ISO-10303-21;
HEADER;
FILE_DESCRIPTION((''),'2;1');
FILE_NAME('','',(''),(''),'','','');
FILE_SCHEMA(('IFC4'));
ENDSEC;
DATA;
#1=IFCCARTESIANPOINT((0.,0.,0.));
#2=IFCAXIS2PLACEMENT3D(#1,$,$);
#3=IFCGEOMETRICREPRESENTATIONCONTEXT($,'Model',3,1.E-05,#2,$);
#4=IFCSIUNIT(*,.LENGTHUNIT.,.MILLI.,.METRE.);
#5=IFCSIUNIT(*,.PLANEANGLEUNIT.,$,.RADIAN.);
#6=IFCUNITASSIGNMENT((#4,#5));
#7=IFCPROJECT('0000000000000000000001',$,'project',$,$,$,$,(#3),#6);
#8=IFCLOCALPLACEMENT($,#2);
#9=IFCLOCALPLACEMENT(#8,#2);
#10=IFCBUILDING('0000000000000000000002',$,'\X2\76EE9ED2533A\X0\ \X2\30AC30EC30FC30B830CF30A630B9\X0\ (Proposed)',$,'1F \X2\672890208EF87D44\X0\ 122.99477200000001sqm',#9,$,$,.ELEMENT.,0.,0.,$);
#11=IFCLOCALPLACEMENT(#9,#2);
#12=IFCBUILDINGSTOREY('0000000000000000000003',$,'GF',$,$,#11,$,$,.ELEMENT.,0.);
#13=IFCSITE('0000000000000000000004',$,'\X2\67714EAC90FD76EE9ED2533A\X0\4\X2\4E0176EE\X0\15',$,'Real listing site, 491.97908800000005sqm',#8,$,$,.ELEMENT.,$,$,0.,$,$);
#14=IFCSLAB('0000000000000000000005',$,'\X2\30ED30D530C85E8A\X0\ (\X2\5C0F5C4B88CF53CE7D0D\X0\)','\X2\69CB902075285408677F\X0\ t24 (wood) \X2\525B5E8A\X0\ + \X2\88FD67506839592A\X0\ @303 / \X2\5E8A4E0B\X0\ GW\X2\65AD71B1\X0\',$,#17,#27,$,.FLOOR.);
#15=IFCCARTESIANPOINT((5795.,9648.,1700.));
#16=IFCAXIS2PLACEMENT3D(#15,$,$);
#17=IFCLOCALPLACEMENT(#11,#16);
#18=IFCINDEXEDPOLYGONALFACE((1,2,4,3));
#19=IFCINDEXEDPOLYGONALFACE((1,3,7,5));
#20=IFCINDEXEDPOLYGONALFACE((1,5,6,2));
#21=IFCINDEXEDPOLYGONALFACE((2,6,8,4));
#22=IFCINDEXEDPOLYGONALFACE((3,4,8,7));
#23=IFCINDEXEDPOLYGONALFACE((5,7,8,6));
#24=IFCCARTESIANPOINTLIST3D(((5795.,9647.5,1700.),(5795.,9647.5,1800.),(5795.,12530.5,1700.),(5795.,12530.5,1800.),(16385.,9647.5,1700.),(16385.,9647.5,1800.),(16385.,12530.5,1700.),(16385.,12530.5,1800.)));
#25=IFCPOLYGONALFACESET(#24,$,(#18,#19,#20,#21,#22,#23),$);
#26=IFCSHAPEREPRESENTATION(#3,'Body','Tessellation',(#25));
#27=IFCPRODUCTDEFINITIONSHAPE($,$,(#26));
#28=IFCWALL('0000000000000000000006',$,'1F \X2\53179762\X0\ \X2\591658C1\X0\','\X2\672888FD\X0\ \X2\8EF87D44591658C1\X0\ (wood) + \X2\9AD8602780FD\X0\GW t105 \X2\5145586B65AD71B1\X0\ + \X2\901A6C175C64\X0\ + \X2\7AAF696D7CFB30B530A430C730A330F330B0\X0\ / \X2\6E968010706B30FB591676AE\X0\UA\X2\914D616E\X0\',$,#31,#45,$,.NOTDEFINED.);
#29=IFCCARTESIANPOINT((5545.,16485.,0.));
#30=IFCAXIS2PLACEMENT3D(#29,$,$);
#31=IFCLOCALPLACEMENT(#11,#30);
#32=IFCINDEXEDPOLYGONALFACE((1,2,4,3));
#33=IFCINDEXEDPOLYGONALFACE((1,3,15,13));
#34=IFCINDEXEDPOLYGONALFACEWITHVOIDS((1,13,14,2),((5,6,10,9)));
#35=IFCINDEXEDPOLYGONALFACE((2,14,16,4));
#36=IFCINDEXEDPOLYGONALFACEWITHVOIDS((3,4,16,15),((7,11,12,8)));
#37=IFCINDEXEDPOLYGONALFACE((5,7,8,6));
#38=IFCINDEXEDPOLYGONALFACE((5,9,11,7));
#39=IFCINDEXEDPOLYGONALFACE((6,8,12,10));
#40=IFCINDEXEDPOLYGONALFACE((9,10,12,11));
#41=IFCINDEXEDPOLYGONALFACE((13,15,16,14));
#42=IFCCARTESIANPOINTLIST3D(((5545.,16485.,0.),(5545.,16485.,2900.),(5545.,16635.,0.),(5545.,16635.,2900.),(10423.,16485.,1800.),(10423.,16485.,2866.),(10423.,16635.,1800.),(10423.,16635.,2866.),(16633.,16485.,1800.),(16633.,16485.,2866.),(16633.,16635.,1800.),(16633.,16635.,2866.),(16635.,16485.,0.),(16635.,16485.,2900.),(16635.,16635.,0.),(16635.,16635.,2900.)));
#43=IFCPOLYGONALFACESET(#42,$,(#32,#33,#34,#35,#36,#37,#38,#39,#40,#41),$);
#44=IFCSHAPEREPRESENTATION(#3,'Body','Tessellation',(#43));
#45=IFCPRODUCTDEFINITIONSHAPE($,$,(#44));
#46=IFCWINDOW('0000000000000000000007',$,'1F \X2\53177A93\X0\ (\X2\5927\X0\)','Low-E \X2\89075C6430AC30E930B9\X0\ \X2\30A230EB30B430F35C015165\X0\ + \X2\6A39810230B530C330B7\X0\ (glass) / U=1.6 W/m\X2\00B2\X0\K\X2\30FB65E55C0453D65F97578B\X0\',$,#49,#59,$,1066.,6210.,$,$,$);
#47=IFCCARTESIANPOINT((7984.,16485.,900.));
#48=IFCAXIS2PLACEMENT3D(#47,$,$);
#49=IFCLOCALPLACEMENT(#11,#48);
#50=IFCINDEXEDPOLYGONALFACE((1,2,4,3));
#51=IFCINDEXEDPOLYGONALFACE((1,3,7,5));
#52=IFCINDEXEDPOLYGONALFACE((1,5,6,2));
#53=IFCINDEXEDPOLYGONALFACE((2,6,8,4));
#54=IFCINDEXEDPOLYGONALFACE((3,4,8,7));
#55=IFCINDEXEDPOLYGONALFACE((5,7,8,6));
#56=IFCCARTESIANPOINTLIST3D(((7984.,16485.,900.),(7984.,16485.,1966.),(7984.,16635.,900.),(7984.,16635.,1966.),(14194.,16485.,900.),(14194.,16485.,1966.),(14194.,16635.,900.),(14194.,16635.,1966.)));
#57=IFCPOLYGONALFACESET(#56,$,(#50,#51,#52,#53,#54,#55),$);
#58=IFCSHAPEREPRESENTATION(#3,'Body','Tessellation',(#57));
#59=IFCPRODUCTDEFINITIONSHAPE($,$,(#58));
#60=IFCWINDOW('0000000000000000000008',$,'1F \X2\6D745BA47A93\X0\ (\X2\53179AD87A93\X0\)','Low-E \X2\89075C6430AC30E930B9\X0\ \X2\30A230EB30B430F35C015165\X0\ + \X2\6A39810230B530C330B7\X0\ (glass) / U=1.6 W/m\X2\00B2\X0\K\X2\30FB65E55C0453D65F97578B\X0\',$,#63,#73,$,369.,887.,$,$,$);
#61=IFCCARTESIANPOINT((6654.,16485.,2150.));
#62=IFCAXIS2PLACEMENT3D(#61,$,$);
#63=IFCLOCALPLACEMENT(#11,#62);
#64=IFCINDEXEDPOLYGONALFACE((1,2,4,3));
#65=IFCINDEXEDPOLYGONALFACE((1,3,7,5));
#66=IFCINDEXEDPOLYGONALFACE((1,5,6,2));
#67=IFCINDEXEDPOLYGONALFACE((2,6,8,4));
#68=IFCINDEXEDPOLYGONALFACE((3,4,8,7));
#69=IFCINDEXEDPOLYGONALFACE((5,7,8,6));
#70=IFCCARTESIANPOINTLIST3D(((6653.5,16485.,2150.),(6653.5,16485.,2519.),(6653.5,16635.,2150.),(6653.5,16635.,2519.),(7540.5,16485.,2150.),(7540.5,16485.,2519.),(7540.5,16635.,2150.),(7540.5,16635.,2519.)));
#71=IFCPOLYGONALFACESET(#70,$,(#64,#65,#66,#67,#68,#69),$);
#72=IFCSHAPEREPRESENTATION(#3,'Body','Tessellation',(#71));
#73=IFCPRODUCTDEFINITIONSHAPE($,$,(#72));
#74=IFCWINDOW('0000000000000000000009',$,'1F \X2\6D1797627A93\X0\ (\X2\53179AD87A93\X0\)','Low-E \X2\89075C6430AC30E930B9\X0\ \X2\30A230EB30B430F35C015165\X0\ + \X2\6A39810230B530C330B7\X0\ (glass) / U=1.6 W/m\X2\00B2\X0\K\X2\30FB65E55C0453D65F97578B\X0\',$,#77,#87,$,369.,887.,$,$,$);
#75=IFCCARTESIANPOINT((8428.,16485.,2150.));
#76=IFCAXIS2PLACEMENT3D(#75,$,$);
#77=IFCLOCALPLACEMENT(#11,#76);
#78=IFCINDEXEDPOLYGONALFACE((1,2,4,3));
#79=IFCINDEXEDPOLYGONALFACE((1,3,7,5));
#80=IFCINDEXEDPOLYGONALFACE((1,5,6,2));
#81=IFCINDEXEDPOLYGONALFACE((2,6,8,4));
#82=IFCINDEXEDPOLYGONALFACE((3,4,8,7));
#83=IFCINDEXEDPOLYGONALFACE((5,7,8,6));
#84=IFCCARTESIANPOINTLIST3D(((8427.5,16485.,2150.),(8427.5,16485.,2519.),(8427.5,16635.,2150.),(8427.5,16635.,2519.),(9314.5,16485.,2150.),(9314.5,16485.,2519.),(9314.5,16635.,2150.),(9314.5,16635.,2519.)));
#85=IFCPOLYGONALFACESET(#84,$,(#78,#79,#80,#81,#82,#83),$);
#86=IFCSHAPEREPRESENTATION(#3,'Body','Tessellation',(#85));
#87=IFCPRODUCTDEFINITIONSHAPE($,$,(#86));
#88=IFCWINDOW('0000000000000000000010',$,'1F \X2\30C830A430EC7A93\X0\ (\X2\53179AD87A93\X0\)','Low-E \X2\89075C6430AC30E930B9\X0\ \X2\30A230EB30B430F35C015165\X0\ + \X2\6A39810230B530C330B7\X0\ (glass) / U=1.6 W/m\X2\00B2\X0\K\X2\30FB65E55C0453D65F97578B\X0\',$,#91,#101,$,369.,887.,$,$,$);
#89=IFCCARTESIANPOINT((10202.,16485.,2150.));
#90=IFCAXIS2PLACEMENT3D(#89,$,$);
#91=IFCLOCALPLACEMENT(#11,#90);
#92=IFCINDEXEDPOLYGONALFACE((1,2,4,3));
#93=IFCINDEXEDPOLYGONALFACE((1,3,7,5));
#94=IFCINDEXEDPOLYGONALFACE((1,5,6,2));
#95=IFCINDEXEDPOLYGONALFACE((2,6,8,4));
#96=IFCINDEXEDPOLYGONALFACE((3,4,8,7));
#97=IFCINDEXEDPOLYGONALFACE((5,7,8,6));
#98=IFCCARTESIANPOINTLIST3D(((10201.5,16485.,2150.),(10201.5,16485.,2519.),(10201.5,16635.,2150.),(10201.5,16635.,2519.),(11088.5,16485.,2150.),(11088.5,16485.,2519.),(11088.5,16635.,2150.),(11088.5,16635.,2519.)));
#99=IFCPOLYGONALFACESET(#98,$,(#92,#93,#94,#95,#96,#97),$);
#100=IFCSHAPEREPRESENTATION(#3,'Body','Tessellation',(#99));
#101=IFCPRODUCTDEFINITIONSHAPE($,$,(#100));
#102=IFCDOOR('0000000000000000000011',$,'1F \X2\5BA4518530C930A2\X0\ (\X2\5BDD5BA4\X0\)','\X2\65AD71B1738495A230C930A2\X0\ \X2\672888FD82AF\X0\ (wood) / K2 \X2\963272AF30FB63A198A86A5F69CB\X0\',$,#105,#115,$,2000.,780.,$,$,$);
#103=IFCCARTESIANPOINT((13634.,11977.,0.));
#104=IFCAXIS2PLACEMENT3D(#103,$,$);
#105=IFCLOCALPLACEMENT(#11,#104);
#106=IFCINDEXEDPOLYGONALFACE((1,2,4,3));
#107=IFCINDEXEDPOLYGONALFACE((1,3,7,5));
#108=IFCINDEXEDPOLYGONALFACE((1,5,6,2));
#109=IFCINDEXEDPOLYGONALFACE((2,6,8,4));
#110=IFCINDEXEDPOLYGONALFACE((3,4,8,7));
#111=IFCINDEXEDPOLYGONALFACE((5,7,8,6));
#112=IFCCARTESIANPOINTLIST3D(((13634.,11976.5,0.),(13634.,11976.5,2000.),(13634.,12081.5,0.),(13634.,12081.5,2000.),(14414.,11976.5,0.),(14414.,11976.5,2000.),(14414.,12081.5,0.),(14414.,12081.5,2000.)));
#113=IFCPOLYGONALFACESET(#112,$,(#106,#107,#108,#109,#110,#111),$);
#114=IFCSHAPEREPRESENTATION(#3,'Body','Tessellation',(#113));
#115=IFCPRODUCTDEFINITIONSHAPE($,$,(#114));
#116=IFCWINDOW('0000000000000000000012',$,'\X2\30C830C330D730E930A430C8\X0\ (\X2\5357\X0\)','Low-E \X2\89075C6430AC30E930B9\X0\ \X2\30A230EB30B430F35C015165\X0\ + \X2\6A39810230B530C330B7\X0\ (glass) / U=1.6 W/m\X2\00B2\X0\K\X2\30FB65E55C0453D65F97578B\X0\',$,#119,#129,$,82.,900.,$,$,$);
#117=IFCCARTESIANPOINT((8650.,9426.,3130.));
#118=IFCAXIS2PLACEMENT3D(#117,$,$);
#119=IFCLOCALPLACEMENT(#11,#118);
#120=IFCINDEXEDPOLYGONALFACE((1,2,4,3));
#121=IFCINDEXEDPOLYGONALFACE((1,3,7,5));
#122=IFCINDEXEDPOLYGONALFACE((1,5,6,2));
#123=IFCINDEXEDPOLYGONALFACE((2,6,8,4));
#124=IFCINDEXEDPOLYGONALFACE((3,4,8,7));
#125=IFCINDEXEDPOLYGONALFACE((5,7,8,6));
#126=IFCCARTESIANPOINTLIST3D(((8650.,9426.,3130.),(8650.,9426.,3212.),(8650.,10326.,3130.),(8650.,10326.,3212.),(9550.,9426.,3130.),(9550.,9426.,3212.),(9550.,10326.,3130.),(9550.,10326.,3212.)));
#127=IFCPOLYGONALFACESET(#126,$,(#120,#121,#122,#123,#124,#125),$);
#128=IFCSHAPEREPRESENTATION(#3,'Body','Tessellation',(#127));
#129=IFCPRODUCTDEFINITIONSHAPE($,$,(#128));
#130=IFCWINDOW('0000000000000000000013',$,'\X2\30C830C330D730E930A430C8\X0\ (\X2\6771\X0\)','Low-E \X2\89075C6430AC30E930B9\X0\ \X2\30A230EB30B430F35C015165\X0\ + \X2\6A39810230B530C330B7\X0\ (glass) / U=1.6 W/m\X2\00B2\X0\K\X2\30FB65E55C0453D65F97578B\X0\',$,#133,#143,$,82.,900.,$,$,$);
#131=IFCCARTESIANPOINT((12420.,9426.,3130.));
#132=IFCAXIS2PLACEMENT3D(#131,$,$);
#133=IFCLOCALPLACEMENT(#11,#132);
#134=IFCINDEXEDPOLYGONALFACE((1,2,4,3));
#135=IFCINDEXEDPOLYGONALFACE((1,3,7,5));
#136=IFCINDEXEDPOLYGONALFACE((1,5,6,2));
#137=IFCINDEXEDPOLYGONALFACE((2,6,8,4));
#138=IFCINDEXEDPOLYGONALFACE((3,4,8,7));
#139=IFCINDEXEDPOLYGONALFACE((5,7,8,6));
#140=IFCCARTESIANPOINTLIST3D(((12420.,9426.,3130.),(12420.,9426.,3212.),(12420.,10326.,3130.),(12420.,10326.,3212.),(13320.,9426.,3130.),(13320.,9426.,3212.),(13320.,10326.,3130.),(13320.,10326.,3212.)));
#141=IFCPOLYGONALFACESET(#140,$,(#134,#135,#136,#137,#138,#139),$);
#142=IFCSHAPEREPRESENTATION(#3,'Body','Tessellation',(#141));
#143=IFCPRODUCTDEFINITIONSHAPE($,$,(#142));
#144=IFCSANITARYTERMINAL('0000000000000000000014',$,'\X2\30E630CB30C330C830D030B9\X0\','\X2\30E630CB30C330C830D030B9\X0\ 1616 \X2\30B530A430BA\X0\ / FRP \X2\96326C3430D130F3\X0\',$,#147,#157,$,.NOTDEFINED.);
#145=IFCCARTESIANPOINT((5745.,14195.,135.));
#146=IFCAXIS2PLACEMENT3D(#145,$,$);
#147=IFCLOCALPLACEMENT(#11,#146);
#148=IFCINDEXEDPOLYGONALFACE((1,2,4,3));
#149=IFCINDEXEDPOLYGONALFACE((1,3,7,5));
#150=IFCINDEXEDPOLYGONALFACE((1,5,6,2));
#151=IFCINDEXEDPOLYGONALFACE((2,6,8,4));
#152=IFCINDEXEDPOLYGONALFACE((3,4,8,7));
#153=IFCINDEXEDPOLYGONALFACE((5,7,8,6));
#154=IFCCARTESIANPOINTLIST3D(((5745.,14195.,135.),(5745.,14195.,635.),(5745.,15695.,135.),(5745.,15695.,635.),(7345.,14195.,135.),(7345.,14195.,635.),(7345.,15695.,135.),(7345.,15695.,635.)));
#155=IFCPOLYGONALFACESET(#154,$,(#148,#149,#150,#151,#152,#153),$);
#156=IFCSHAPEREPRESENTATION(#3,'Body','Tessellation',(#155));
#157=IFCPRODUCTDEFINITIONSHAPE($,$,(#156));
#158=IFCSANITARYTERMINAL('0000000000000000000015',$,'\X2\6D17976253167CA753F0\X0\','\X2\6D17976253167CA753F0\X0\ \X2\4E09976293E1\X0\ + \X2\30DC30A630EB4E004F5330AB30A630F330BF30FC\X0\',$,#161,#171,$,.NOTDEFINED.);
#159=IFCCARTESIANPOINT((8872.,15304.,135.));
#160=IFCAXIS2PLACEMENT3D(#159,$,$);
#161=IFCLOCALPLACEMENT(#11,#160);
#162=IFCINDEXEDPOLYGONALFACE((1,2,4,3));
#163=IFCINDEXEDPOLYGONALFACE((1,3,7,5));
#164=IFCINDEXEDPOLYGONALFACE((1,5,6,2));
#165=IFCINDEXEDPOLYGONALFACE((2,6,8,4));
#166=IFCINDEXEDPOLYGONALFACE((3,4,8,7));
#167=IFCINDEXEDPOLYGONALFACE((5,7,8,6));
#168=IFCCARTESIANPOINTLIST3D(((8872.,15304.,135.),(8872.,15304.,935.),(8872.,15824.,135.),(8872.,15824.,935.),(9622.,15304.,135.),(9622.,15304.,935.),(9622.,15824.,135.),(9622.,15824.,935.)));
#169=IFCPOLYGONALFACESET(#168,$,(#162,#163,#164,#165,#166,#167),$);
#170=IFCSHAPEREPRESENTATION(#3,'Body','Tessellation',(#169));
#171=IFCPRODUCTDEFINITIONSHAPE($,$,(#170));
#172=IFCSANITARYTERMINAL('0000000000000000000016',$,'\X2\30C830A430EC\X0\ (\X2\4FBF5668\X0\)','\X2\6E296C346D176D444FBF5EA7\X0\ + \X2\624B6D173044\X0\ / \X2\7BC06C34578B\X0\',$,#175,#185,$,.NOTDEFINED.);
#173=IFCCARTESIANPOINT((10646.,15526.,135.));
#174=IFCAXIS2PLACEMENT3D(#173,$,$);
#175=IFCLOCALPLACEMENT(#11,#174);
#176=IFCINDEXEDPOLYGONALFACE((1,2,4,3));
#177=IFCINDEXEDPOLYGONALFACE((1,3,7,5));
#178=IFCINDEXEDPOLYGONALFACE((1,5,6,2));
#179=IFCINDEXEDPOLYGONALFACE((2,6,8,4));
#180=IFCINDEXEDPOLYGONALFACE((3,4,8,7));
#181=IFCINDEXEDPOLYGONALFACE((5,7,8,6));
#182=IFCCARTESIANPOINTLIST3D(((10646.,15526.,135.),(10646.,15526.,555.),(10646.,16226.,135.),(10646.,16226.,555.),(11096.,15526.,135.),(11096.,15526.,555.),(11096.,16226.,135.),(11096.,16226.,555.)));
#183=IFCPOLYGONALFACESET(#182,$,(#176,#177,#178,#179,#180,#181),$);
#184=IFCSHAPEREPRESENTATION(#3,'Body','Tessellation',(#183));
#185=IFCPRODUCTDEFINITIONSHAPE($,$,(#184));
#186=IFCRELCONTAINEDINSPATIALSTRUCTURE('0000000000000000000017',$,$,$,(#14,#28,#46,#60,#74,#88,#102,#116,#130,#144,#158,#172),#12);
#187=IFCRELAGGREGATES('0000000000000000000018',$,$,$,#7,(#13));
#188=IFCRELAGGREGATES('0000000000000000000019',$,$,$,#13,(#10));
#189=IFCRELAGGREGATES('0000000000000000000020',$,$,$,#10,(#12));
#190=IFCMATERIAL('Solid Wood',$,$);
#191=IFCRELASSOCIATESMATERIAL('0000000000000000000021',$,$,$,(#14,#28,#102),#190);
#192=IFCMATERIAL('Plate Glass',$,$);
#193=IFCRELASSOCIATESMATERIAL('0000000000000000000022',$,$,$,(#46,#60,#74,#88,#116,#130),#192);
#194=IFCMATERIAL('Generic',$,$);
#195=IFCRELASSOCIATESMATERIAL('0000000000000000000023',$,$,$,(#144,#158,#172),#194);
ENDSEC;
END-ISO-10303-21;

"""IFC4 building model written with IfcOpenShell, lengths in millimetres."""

from ifc_helpers import new_model, si_unit, frame, frame_2d, origin, place, context, project, spatial, rectangle, extrude, material, element, fill, save


model = new_model("IFC4")

# Units and contexts
model_context = context("Model", 3, precision=1e-05, world=origin())
ifc_project = project(units=[si_unit("LENGTHUNIT", "METRE", prefix="MILLI"), si_unit("PLANEANGLEUNIT", "RADIAN")], contexts=[model_context])

# Site, building, storey
site_placement = place(None, origin())
site = spatial("IfcSite", under=ifc_project, at=site_placement, Name="東京都目黒区4丁目15", ObjectType="Real listing site, 491.97908800000005sqm", CompositionType="ELEMENT", RefElevation=0.0)
building_placement = place(site_placement, origin())
building = spatial("IfcBuilding", under=site, at=building_placement, Name="目黒区 ガレージハウス (Proposed)", ObjectType="1F 木造軸組 122.99477200000001sqm", CompositionType="ELEMENT", ElevationOfRefHeight=0.0, ElevationOfTerrain=0.0)
storey_placement = place(building_placement, origin())
storey = spatial("IfcBuildingStorey", under=building, at=storey_placement, Name="GF", CompositionType="ELEMENT", Elevation=0.0)

# Slab
ifc_material_1 = material(Name="Solid Wood")
slab_placement = place(storey_placement, frame((5795.0, 9648.0, 1700.0)))
element("IfcSlab", 1, at=slab_placement, inside=storey, material=ifc_material_1, Name="ロフト床 (小屋裏収納)", Description="構造用合板 t24 (wood) 剛床 + 製材根太 @303 / 床下 GW断熱", PredefinedType="FLOOR", context=model_context, shape_type="SweptSolid", body=[
    extrude(rectangle(XDim=10590.0, YDim=2883.0, at=frame_2d((5295.0, 1441.0))), frame((5795.0, 9648.0, 1700.0)), (0.0, 0.0, 1.0), 100.0),
])

# Wall, openings, windows
wall_1_placement = place(storey_placement, frame((5545.0, 16485.0, 0.0)))
wall_1 = element("IfcWall", 2, at=wall_1_placement, inside=storey, material=ifc_material_1, Name="1F 北面 外壁", Description="木製 軸組外壁 (wood) + 高性能GW t105 充填断熱 + 通気層 + 窯業系サイディング / 準耐火・外皮UA配慮", PredefinedType="NOTDEFINED", context=model_context, shape_type="SweptSolid", body=[
    extrude(rectangle(XDim=11090.0, YDim=150.0, at=frame_2d((5545.0, 75.0))), frame((5545.0, 16485.0, 0.0)), (0.0, 0.0, 1.0), 2900.0),
])
opening_1_placement = place(storey_placement, frame((7984.0, 16485.0, 900.0)))
opening_1 = element("IfcOpeningElement", 3, at=opening_1_placement, cuts=wall_1, PredefinedType="NOTDEFINED", context=model_context, shape_type="SweptSolid", body=[
    extrude(rectangle(XDim=6210.0, YDim=150.0, at=frame_2d((3105.0, 75.0))), frame((7984.0, 16485.0, 900.0)), (0.0, 0.0, 1.0), 1066.0),
])
opening_2_placement = place(storey_placement, frame((6654.0, 16485.0, 2150.0)))
opening_2 = element("IfcOpeningElement", 4, at=opening_2_placement, cuts=wall_1, PredefinedType="NOTDEFINED", context=model_context, shape_type="SweptSolid", body=[
    extrude(rectangle(XDim=887.0, YDim=150.0, at=frame_2d((443.0, 75.0))), frame((6654.0, 16485.0, 2150.0)), (0.0, 0.0, 1.0), 369.0),
])
opening_3_placement = place(storey_placement, frame((8428.0, 16485.0, 2150.0)))
opening_3 = element("IfcOpeningElement", 5, at=opening_3_placement, cuts=wall_1, PredefinedType="NOTDEFINED", context=model_context, shape_type="SweptSolid", body=[
    extrude(rectangle(XDim=887.0, YDim=150.0, at=frame_2d((443.0, 75.0))), frame((8428.0, 16485.0, 2150.0)), (0.0, 0.0, 1.0), 369.0),
])
opening_4_placement = place(storey_placement, frame((10202.0, 16485.0, 2150.0)))
opening_4 = element("IfcOpeningElement", 6, at=opening_4_placement, cuts=wall_1, PredefinedType="NOTDEFINED", context=model_context, shape_type="SweptSolid", body=[
    extrude(rectangle(XDim=887.0, YDim=150.0, at=frame_2d((443.0, 75.0))), frame((10202.0, 16485.0, 2150.0)), (0.0, 0.0, 1.0), 369.0),
])
ifc_material_2 = material(Name="Plate Glass")
window_1_placement = place(storey_placement, frame((7984.0, 16485.0, 900.0)))
window_1 = element("IfcWindow", 7, at=window_1_placement, inside=storey, material=ifc_material_2, Name="1F 北窓 (大)", Description="Low-E 複層ガラス アルゴン封入 + 樹脂サッシ (glass) / U=1.6 W/m²K・日射取得型", OverallHeight=1066.0, OverallWidth=6210.0, context=model_context, shape_type="SweptSolid", body=[
    extrude(rectangle(XDim=6210.0, YDim=150.0, at=frame_2d((3105.0, 75.0))), frame((7984.0, 16485.0, 900.0)), (0.0, 0.0, 1.0), 1066.0),
])
fill(opening_1, window_1)
window_2_placement = place(storey_placement, frame((6654.0, 16485.0, 2150.0)))
window_2 = element("IfcWindow", 8, at=window_2_placement, inside=storey, material=ifc_material_2, Name="1F 浴室窓 (北高窓)", Description="Low-E 複層ガラス アルゴン封入 + 樹脂サッシ (glass) / U=1.6 W/m²K・日射取得型", OverallHeight=369.0, OverallWidth=887.0, context=model_context, shape_type="SweptSolid", body=[
    extrude(rectangle(XDim=887.0, YDim=150.0, at=frame_2d((443.0, 75.0))), frame((6654.0, 16485.0, 2150.0)), (0.0, 0.0, 1.0), 369.0),
])
fill(opening_2, window_2)
window_3_placement = place(storey_placement, frame((8428.0, 16485.0, 2150.0)))
window_3 = element("IfcWindow", 9, at=window_3_placement, inside=storey, material=ifc_material_2, Name="1F 洗面窓 (北高窓)", Description="Low-E 複層ガラス アルゴン封入 + 樹脂サッシ (glass) / U=1.6 W/m²K・日射取得型", OverallHeight=369.0, OverallWidth=887.0, context=model_context, shape_type="SweptSolid", body=[
    extrude(rectangle(XDim=887.0, YDim=150.0, at=frame_2d((443.0, 75.0))), frame((8428.0, 16485.0, 2150.0)), (0.0, 0.0, 1.0), 369.0),
])
fill(opening_3, window_3)
window_4_placement = place(storey_placement, frame((10202.0, 16485.0, 2150.0)))
window_4 = element("IfcWindow", 10, at=window_4_placement, inside=storey, material=ifc_material_2, Name="1F トイレ窓 (北高窓)", Description="Low-E 複層ガラス アルゴン封入 + 樹脂サッシ (glass) / U=1.6 W/m²K・日射取得型", OverallHeight=369.0, OverallWidth=887.0, context=model_context, shape_type="SweptSolid", body=[
    extrude(rectangle(XDim=887.0, YDim=150.0, at=frame_2d((443.0, 75.0))), frame((10202.0, 16485.0, 2150.0)), (0.0, 0.0, 1.0), 369.0),
])
fill(opening_4, window_4)

# Door
door_1_placement = place(storey_placement, frame((13634.0, 11977.0, 0.0)))
element("IfcDoor", 11, at=door_1_placement, inside=storey, material=ifc_material_1, Name="1F 室内ドア (寝室)", Description="断熱玄関ドア 木製芯 (wood) / K2 防犯・採風機構", OverallHeight=2000.0, OverallWidth=780.0, context=model_context, shape_type="SweptSolid", body=[
    extrude(rectangle(XDim=780.0, YDim=105.0, at=frame_2d((390.0, 52.0))), frame((13634.0, 11977.0, 0.0)), (0.0, 0.0, 1.0), 2000.0),
])

# Windows
window_5_placement = place(storey_placement, frame((8650.0, 9426.0, 3130.0)))
element("IfcWindow", 12, at=window_5_placement, inside=storey, material=ifc_material_2, Name="トップライト (南)", Description="Low-E 複層ガラス アルゴン封入 + 樹脂サッシ (glass) / U=1.6 W/m²K・日射取得型", OverallHeight=82.0, OverallWidth=900.0, context=model_context, shape_type="SweptSolid", body=[
    extrude(rectangle(XDim=900.0, YDim=900.0, at=frame_2d((450.0, 450.0))), frame((8650.0, 9426.0, 3130.0)), (0.0, 0.0, 1.0), 82.0),
])
window_6_placement = place(storey_placement, frame((12420.0, 9426.0, 3130.0)))
element("IfcWindow", 13, at=window_6_placement, inside=storey, material=ifc_material_2, Name="トップライト (東)", Description="Low-E 複層ガラス アルゴン封入 + 樹脂サッシ (glass) / U=1.6 W/m²K・日射取得型", OverallHeight=82.0, OverallWidth=900.0, context=model_context, shape_type="SweptSolid", body=[
    extrude(rectangle(XDim=900.0, YDim=900.0, at=frame_2d((450.0, 450.0))), frame((12420.0, 9426.0, 3130.0)), (0.0, 0.0, 1.0), 82.0),
])

# Sanitary terminals
ifc_material_3 = material(Name="Generic")
sanitary_terminal_1_placement = place(storey_placement, frame((5745.0, 14195.0, 135.0)))
element("IfcSanitaryTerminal", 14, at=sanitary_terminal_1_placement, inside=storey, material=ifc_material_3, Name="ユニットバス", Description="ユニットバス 1616 サイズ / FRP 防水パン", PredefinedType="NOTDEFINED", context=model_context, shape_type="SweptSolid", body=[
    extrude(rectangle(XDim=1600.0, YDim=1500.0, at=frame_2d((800.0, 750.0))), frame((5745.0, 14195.0, 135.0)), (0.0, 0.0, 1.0), 500.0),
])
sanitary_terminal_2_placement = place(storey_placement, frame((8872.0, 15304.0, 135.0)))
element("IfcSanitaryTerminal", 15, at=sanitary_terminal_2_placement, inside=storey, material=ifc_material_3, Name="洗面化粧台", Description="洗面化粧台 三面鏡 + ボウル一体カウンター", PredefinedType="NOTDEFINED", context=model_context, shape_type="SweptSolid", body=[
    extrude(rectangle(XDim=750.0, YDim=520.0, at=frame_2d((375.0, 260.0))), frame((8872.0, 15304.0, 135.0)), (0.0, 0.0, 1.0), 800.0),
])
sanitary_terminal_3_placement = place(storey_placement, frame((10646.0, 15526.0, 135.0)))
element("IfcSanitaryTerminal", 16, at=sanitary_terminal_3_placement, inside=storey, material=ifc_material_3, Name="トイレ (便器)", Description="温水洗浄便座 + 手洗い / 節水型", PredefinedType="NOTDEFINED", context=model_context, shape_type="SweptSolid", body=[
    extrude(rectangle(XDim=450.0, YDim=700.0, at=frame_2d((225.0, 350.0))), frame((10646.0, 15526.0, 135.0)), (0.0, 0.0, 1.0), 420.0),
])

save(model, "model.ifc")
